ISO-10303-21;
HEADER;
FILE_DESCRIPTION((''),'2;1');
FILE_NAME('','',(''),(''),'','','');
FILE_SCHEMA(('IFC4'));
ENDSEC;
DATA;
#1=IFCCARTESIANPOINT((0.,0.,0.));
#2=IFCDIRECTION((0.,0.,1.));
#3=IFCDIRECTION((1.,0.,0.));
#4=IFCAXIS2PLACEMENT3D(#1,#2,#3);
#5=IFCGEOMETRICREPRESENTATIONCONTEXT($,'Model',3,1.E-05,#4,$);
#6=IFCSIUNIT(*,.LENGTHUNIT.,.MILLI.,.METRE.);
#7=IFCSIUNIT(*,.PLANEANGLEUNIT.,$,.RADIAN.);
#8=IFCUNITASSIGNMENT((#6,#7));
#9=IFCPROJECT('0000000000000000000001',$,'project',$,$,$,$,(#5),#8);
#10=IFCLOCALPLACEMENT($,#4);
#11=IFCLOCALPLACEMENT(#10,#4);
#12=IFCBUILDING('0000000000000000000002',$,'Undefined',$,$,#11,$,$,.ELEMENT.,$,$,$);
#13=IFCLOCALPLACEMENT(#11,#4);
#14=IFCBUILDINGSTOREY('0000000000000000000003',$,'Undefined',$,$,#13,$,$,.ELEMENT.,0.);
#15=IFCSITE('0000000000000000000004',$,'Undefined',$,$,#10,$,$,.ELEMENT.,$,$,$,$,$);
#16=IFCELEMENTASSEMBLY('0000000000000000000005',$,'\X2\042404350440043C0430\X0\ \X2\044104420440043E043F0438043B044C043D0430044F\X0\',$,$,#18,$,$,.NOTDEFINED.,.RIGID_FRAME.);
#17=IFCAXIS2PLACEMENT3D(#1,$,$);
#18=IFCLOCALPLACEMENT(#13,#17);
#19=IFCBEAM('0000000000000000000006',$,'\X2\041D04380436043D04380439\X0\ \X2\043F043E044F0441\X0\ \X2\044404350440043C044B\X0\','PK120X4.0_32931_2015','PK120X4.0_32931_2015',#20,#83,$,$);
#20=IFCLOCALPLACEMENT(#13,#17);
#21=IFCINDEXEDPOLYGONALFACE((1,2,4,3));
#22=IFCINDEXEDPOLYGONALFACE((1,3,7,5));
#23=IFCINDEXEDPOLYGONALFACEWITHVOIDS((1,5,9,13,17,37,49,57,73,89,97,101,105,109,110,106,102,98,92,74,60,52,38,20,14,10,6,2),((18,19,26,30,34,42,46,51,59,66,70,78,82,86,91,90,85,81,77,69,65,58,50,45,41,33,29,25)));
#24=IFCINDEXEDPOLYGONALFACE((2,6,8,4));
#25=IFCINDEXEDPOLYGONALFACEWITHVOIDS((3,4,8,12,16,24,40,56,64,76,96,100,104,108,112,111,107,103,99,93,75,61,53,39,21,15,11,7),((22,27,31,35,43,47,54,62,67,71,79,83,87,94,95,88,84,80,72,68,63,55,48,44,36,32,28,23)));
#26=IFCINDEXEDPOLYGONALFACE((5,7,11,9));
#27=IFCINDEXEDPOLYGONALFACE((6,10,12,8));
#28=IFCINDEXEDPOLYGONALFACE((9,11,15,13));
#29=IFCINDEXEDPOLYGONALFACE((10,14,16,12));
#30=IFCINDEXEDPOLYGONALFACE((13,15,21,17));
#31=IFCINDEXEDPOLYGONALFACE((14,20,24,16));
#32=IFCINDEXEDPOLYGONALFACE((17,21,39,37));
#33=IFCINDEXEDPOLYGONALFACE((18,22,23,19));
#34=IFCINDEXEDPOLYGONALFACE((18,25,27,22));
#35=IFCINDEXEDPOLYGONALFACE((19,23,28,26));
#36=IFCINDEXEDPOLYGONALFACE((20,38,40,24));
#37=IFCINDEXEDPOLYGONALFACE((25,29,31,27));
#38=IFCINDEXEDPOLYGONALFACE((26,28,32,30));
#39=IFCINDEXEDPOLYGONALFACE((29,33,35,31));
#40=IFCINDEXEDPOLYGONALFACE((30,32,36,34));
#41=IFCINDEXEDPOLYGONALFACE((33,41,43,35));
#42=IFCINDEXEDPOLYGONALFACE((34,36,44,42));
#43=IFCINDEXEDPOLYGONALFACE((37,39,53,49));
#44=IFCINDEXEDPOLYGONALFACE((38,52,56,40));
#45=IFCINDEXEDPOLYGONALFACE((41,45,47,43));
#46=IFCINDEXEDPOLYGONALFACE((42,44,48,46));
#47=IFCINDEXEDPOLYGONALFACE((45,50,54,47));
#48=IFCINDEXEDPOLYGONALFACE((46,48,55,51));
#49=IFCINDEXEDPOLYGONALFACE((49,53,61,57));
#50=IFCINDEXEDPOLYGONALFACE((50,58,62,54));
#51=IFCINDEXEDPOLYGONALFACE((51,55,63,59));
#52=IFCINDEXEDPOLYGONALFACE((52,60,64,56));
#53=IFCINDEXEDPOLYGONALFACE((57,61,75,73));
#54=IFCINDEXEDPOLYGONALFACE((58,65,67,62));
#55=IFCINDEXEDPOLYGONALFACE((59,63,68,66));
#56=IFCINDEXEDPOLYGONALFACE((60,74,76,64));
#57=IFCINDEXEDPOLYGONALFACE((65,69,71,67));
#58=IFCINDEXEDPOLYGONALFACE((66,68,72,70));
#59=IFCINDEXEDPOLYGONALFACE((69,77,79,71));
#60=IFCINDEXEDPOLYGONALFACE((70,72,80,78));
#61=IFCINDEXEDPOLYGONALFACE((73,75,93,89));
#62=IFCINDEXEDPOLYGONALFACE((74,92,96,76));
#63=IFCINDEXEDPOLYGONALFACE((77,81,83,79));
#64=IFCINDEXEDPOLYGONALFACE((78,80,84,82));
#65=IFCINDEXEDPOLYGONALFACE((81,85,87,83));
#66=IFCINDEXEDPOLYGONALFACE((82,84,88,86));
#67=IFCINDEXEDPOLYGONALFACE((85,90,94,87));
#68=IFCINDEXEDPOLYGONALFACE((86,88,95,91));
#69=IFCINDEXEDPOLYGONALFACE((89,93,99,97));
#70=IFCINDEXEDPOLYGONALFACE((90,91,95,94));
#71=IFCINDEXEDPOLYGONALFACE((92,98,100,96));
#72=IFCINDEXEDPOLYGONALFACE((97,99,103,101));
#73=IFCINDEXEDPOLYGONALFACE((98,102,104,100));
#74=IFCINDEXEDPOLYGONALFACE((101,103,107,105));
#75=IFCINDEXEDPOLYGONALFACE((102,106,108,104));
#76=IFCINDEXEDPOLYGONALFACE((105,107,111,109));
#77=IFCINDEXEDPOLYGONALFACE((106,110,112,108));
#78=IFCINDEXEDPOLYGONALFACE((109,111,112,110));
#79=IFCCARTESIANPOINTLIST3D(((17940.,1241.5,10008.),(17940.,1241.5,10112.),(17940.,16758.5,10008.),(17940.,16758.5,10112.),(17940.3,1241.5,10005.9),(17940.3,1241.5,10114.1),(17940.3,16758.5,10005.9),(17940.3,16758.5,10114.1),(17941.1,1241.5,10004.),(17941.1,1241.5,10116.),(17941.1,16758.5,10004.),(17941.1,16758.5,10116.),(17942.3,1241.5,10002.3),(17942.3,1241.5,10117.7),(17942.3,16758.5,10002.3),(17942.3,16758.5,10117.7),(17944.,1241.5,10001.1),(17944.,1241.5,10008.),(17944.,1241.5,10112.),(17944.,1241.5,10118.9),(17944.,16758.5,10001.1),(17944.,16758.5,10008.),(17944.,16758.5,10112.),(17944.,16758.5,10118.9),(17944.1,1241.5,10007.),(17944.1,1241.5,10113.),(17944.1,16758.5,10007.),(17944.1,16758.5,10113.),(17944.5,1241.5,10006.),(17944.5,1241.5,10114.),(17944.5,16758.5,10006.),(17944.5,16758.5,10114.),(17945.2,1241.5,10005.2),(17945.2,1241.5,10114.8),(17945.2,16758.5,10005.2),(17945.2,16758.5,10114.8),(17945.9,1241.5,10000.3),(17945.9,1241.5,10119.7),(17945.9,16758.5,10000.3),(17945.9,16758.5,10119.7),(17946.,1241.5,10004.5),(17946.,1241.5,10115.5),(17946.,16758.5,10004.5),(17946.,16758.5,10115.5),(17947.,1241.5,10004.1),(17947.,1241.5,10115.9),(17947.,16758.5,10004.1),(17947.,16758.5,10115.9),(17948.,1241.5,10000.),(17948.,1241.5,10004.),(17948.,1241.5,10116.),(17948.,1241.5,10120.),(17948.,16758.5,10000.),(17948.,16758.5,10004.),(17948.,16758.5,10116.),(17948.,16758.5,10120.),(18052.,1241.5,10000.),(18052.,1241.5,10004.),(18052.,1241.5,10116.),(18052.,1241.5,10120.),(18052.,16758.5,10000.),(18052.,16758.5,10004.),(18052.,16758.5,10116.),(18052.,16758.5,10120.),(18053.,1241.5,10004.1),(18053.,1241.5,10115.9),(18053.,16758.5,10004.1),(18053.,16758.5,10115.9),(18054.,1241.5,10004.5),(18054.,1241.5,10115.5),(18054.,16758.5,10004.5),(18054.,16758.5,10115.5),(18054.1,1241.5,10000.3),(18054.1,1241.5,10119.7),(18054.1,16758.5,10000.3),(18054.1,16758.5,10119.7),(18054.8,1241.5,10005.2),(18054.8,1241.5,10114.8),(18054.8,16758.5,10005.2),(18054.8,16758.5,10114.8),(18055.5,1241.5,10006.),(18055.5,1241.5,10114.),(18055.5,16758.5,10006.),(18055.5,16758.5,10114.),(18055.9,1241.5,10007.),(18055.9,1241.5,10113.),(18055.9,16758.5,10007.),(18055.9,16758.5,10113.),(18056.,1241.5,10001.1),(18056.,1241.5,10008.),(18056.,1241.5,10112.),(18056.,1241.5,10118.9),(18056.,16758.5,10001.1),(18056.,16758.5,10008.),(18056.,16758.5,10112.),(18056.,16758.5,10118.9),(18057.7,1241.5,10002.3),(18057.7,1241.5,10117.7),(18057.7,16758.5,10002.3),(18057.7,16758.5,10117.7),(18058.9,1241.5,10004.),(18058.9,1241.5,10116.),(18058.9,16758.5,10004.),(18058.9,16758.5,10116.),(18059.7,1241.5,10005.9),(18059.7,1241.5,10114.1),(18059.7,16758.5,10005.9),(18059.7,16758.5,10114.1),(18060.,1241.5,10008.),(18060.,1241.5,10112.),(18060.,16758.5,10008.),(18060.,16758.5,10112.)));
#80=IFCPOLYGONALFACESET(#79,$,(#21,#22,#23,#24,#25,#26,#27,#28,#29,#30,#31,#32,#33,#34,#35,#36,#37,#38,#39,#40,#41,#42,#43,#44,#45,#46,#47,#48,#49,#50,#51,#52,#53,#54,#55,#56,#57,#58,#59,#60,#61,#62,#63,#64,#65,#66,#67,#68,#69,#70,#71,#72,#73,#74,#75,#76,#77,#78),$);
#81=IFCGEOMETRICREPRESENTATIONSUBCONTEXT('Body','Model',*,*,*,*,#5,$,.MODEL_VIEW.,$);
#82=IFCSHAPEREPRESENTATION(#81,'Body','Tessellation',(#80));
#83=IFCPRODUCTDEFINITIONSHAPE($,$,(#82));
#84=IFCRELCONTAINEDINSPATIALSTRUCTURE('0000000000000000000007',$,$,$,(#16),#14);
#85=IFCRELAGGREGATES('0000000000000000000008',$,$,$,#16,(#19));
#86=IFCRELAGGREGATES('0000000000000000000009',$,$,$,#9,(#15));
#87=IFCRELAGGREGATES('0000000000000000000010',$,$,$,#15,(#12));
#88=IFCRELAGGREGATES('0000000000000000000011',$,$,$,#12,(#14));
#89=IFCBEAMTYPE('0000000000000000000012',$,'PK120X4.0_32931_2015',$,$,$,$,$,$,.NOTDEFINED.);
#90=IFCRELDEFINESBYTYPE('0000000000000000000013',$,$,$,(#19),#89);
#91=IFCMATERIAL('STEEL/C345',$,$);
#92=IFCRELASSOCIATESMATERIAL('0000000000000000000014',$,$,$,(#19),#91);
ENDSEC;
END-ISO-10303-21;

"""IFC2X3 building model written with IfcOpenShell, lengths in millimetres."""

from ifc_helpers import new_model, si_unit, frame, origin_with_axes, origin_2d_with_axis, place, context, subcontext, project, spatial, hollow_rectangle, extrude, material, type_object, element, aggregate, save


model = new_model("IFC2X3")

# Units and contexts
model_context = context("Model", 3, precision=1e-05, world=origin_with_axes())
body_context = subcontext(model_context, "Body", "Model", "MODEL_VIEW")
ifc_project = project(units=[si_unit("LENGTHUNIT", "METRE", prefix="MILLI"), si_unit("PLANEANGLEUNIT", "RADIAN")], contexts=[model_context])

# Site, building, storey
site_placement = place(None, origin_with_axes())
site = spatial("IfcSite", under=ifc_project, at=site_placement, Name="Undefined", CompositionType="ELEMENT")
building_placement = place(site_placement, origin_with_axes())
building = spatial("IfcBuilding", under=site, at=building_placement, Name="Undefined", CompositionType="ELEMENT")
storey_placement = place(building_placement, origin_with_axes())
storey = spatial("IfcBuildingStorey", under=building, at=storey_placement, Name="Undefined", CompositionType="ELEMENT", Elevation=0.0)

# Element assembly
assembly_1_placement = place(storey_placement, origin_with_axes())
assembly_1 = element("IfcElementAssembly", 1, at=assembly_1_placement, inside=storey, Name="Ферма стропильная", AssemblyPlace="NOTDEFINED", PredefinedType="RIGID_FRAME")

# Beam
ifc_material_1 = material(Name="STEEL/C345")
beam_type_1 = type_object("IfcBeamType", Name="PK120X4.0_32931_2015", PredefinedType="NOTDEFINED")
beam_1_placement = place(assembly_1_placement, frame((18000.0, 1241.5, 10060.0), z_axis=(0.0, 0.0, 1.0), x_axis=(0.0, 1.0, 0.0)))
beam_1 = element("IfcBeam", 2, at=beam_1_placement, type_object=beam_type_1, material=ifc_material_1, Name="Нижний пояс фермы", Description="PK120X4.0_32931_2015", ObjectType="PK120X4.0_32931_2015", context=body_context, shape_type="SweptSolid", body=[
    extrude(hollow_rectangle(XDim=120.0, YDim=120.0, WallThickness=4.0, InnerFilletRadius=4.0, OuterFilletRadius=8.0, at=origin_2d_with_axis()), frame((15517.0, 0.0, 0.0), z_axis=(-1.0, 0.0, 0.0), x_axis=(0.0, -1.0, 0.0)), (0.0, 0.0, 1.0), 15517.0),
])
aggregate(assembly_1, [beam_1])

save(model, "model.ifc")
